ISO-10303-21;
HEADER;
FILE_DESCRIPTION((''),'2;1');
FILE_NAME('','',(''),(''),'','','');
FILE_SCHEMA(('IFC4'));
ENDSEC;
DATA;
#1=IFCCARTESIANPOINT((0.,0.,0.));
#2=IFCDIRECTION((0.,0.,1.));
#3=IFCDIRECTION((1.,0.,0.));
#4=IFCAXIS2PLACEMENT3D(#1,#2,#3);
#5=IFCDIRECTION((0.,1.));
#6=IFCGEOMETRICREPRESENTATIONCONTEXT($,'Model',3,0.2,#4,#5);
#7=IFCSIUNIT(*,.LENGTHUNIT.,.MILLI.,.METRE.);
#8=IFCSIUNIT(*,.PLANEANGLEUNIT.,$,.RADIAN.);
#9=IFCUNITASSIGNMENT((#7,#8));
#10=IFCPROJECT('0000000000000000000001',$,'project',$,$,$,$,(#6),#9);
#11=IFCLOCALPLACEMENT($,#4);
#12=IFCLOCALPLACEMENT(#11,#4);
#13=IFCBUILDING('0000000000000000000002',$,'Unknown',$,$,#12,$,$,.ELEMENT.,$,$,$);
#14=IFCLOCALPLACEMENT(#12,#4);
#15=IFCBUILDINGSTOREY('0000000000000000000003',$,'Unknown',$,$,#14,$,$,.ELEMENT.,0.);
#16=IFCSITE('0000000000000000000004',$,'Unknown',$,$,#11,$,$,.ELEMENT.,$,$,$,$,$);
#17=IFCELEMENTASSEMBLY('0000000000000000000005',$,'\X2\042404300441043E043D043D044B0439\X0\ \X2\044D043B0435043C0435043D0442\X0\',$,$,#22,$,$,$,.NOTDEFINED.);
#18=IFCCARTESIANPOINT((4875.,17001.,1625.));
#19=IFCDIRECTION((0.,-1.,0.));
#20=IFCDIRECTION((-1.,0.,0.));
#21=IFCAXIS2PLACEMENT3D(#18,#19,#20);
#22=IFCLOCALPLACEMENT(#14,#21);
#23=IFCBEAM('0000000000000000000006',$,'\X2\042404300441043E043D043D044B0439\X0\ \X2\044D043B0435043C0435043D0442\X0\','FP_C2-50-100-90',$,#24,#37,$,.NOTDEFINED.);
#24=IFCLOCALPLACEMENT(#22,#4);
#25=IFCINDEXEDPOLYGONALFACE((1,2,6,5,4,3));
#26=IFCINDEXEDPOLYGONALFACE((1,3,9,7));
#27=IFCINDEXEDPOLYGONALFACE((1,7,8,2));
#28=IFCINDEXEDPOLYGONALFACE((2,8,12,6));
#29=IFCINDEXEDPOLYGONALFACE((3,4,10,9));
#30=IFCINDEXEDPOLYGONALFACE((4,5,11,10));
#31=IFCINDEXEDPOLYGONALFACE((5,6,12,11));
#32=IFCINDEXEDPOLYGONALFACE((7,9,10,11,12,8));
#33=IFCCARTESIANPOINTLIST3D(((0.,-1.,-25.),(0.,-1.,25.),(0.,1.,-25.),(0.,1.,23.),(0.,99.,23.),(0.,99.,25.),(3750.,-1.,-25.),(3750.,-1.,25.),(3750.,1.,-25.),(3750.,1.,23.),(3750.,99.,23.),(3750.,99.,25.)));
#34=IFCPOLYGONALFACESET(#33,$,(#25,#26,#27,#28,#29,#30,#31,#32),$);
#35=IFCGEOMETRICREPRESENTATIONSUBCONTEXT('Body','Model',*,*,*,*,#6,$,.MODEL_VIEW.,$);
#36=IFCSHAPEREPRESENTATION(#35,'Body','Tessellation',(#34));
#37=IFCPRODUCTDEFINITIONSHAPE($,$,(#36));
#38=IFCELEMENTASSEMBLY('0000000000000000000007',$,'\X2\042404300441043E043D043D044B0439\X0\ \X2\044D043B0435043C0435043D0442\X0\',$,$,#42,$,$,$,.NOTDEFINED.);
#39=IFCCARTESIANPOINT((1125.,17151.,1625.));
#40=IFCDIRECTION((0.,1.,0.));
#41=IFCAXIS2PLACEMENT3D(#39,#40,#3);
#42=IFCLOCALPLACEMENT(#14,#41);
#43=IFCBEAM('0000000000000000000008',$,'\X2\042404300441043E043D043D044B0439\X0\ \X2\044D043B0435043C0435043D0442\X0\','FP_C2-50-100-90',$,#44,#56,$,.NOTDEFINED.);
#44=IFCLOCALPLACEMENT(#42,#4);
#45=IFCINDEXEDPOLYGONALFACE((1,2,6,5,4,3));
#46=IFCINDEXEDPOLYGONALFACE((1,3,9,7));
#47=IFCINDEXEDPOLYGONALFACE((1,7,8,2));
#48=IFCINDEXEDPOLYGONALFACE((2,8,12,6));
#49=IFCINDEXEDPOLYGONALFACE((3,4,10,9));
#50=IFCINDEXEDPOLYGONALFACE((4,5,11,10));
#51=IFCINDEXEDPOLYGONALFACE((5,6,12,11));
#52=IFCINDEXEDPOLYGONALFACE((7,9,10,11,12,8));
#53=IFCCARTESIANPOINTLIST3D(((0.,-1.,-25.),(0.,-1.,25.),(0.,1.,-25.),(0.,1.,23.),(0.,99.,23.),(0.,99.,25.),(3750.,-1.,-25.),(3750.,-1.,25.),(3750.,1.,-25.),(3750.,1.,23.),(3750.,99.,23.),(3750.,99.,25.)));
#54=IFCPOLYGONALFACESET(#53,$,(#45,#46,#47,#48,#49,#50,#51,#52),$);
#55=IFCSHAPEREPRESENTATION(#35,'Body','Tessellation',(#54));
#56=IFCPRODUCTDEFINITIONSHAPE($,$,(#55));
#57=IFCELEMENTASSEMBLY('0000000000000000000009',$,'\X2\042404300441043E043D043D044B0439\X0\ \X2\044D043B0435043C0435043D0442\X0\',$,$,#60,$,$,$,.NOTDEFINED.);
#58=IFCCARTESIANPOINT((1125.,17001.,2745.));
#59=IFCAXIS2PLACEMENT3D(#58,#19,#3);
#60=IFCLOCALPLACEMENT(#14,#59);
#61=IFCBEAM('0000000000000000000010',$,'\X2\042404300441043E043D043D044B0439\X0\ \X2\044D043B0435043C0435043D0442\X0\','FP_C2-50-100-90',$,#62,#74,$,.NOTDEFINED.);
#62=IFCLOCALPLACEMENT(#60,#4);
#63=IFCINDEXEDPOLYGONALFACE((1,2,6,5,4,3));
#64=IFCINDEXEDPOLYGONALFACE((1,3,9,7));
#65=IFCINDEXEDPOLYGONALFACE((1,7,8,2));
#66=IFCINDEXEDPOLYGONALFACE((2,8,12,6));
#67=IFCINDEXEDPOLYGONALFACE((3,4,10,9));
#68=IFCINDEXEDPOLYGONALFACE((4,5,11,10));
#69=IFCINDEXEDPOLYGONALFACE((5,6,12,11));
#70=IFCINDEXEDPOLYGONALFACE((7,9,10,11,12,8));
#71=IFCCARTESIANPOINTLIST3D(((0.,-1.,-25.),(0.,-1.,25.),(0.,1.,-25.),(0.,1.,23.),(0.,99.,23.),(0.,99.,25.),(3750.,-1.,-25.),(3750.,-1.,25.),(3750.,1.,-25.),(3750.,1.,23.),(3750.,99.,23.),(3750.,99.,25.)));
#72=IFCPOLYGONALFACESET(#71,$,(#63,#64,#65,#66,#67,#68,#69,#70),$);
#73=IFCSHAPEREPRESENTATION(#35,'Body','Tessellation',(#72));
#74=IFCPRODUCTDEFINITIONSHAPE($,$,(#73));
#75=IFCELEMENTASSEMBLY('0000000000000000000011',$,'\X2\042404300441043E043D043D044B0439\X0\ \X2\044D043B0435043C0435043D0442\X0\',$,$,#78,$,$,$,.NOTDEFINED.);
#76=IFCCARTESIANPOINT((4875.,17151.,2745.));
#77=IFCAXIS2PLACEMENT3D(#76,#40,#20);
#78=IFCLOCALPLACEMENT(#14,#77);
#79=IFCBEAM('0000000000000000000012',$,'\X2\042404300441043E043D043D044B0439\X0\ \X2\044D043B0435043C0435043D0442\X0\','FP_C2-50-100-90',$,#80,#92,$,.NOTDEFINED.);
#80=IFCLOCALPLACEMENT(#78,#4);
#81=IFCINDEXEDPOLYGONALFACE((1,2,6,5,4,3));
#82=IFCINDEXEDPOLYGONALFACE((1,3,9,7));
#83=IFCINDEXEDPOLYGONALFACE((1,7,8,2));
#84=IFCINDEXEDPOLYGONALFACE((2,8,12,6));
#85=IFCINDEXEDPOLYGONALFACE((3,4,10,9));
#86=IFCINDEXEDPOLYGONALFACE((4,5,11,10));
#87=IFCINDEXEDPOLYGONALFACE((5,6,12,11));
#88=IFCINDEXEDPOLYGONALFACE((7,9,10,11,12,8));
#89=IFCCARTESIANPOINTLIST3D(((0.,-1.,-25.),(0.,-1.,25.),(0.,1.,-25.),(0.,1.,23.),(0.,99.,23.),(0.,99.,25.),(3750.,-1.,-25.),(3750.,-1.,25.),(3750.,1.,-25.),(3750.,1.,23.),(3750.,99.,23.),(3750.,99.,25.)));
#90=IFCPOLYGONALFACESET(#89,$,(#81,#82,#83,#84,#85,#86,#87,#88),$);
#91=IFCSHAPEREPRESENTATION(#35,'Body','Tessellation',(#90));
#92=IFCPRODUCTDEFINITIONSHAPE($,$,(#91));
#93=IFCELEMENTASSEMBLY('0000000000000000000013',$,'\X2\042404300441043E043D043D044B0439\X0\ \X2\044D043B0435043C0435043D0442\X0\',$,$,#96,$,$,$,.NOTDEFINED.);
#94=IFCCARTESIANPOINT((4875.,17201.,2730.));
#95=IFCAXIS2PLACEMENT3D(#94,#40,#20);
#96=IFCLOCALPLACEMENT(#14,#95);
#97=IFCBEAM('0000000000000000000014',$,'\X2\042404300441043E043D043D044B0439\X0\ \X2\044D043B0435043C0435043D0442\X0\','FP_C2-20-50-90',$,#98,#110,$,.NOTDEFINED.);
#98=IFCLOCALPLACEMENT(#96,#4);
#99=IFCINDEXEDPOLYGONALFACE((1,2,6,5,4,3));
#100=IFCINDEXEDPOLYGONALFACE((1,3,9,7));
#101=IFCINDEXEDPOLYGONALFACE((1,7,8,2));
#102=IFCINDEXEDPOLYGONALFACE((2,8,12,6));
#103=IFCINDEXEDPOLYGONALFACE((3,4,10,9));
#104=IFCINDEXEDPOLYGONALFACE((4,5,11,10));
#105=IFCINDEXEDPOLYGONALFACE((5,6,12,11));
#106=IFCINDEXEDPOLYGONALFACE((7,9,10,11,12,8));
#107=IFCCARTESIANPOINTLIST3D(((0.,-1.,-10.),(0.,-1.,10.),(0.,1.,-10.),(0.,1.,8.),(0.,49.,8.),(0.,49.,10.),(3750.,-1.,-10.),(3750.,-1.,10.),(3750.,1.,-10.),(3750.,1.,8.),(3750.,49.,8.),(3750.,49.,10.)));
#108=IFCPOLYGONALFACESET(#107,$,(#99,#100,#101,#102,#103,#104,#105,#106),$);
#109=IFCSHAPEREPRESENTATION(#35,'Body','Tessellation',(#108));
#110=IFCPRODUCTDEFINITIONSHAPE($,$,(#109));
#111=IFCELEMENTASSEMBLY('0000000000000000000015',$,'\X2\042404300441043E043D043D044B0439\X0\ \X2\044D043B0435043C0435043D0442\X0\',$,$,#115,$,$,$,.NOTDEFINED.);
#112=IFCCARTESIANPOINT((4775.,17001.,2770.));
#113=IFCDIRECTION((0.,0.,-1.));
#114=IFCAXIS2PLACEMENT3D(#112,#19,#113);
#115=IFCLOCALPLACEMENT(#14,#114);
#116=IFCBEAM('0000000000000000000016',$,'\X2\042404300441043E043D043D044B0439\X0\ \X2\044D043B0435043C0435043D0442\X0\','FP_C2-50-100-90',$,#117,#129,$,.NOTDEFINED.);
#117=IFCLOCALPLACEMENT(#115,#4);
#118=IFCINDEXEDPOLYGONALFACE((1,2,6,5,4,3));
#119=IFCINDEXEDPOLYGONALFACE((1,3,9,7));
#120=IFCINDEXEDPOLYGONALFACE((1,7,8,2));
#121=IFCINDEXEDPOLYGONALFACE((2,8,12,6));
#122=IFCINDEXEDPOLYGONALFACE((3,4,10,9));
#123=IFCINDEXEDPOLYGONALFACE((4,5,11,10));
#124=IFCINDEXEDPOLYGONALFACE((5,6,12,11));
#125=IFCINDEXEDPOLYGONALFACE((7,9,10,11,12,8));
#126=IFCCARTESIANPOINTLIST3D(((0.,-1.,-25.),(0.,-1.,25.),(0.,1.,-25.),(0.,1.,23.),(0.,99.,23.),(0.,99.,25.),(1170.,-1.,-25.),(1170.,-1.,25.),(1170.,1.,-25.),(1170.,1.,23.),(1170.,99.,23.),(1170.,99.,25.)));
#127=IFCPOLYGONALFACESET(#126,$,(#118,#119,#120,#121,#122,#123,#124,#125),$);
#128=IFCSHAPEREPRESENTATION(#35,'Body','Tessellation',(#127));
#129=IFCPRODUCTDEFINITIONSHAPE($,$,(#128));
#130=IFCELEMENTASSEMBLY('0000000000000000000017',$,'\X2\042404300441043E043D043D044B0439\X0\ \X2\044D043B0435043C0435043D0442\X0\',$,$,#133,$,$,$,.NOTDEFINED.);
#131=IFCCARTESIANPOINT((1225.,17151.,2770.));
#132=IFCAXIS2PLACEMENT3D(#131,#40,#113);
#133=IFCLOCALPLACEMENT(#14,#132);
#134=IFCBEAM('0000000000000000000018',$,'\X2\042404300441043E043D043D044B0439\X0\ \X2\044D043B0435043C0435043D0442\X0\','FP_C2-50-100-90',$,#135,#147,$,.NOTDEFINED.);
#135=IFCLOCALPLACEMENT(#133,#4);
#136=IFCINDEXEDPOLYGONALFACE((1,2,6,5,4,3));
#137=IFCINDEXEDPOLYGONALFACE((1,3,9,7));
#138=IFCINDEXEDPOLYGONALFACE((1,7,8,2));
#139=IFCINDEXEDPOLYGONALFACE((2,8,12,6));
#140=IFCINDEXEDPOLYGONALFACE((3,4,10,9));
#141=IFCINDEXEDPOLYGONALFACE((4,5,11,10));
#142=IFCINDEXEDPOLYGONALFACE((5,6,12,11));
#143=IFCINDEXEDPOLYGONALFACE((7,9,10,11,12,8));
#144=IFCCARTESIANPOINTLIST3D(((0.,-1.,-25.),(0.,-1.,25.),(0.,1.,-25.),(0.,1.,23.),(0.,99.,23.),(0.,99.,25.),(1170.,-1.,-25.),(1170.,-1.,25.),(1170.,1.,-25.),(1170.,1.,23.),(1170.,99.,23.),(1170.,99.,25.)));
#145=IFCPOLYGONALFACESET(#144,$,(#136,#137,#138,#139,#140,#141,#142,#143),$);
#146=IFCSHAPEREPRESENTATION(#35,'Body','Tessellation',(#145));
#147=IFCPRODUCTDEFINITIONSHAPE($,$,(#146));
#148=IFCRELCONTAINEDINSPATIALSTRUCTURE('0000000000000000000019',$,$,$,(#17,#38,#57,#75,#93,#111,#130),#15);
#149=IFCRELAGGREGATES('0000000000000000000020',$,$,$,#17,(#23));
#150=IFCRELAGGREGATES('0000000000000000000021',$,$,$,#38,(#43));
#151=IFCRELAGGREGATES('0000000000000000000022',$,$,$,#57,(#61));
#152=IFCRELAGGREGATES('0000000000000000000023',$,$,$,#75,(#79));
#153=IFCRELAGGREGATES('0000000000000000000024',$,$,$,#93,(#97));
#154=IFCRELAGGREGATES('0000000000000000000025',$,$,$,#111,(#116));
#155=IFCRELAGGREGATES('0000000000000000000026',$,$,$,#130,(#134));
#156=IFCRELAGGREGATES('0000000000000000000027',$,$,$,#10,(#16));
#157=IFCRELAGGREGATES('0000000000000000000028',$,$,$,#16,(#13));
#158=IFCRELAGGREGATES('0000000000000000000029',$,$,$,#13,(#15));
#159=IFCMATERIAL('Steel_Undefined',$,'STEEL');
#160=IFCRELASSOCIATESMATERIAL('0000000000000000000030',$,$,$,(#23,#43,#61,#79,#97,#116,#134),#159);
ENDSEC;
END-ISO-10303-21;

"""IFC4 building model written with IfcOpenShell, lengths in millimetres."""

from ifc_helpers import new_model, si_unit, direction, frame, origin_with_axes, place, context, subcontext, project, spatial, line, indexed_curve, outline, extrude, material, element, aggregate, save


model = new_model("IFC4")

# Units and contexts
model_context = context("Model", 3, precision=0.2, world=origin_with_axes(), true_north=direction((0.0, 1.0)))
body_context = subcontext(model_context, "Body", "Model", "MODEL_VIEW")
ifc_project = project(units=[si_unit("LENGTHUNIT", "METRE", prefix="MILLI"), si_unit("PLANEANGLEUNIT", "RADIAN")], contexts=[model_context])

# Site, building, storey
site_placement = place(None, origin_with_axes())
site = spatial("IfcSite", under=ifc_project, at=site_placement, Name="Unknown", CompositionType="ELEMENT")
building_placement = place(site_placement, origin_with_axes())
building = spatial("IfcBuilding", under=site, at=building_placement, Name="Unknown", CompositionType="ELEMENT")
storey_placement = place(building_placement, origin_with_axes())
storey = spatial("IfcBuildingStorey", under=building, at=storey_placement, Name="Unknown", CompositionType="ELEMENT", Elevation=0.0)

# Element assemblies, beams
assembly_1_placement = place(storey_placement, frame((4875.0, 17001.0, 1625.0), z_axis=(0.0, -1.0, 0.0), x_axis=(-1.0, 0.0, 0.0)))
assembly_1 = element("IfcElementAssembly", 1, at=assembly_1_placement, inside=storey, Name="Фасонный элемент", PredefinedType="NOTDEFINED")
ifc_material_1 = material(Name="Steel_Undefined", Category="STEEL")
beam_1_placement = place(assembly_1_placement, origin_with_axes())
beam_1 = element("IfcBeam", 2, at=beam_1_placement, material=ifc_material_1, Name="Фасонный элемент", Description="FP_C2-50-100-90", PredefinedType="NOTDEFINED", context=body_context, shape_type="SolidModel", body=[
    extrude(outline(indexed_curve([(-25.0, -1.0), (25.0, -1.0), (25.0, 99.0), (23.0, 99.0), (23.0, 1.0), (-25.0, 1.0)], segments=[line(1, 2, 3, 4, 5, 6, 1)])), frame((0.0, 0.0, 0.0), z_axis=(-1.0, 0.0, 0.0), x_axis=(0.0, 0.0, 1.0)), (0.0, 0.0, -1.0), 3750.0),
])
aggregate(assembly_1, [beam_1])
assembly_2_placement = place(storey_placement, frame((1125.0, 17151.0, 1625.0), z_axis=(0.0, 1.0, 0.0), x_axis=(1.0, 0.0, 0.0)))
assembly_2 = element("IfcElementAssembly", 3, at=assembly_2_placement, inside=storey, Name="Фасонный элемент", PredefinedType="NOTDEFINED")
beam_2_placement = place(assembly_2_placement, origin_with_axes())
beam_2 = element("IfcBeam", 4, at=beam_2_placement, material=ifc_material_1, Name="Фасонный элемент", Description="FP_C2-50-100-90", PredefinedType="NOTDEFINED", context=body_context, shape_type="SolidModel", body=[
    extrude(outline(indexed_curve([(-25.0, -1.0), (25.0, -1.0), (25.0, 99.0), (23.0, 99.0), (23.0, 1.0), (-25.0, 1.0)], segments=[line(1, 2, 3, 4, 5, 6, 1)])), frame((0.0, 0.0, 0.0), z_axis=(-1.0, 0.0, 0.0), x_axis=(0.0, 0.0, 1.0)), (0.0, 0.0, -1.0), 3750.0),
])
aggregate(assembly_2, [beam_2])
assembly_3_placement = place(storey_placement, frame((1125.0, 17001.0, 2745.0), z_axis=(0.0, -1.0, 0.0), x_axis=(1.0, 0.0, 0.0)))
assembly_3 = element("IfcElementAssembly", 5, at=assembly_3_placement, inside=storey, Name="Фасонный элемент", PredefinedType="NOTDEFINED")
beam_3_placement = place(assembly_3_placement, origin_with_axes())
beam_3 = element("IfcBeam", 6, at=beam_3_placement, material=ifc_material_1, Name="Фасонный элемент", Description="FP_C2-50-100-90", PredefinedType="NOTDEFINED", context=body_context, shape_type="SolidModel", body=[
    extrude(outline(indexed_curve([(-25.0, -1.0), (25.0, -1.0), (25.0, 99.0), (23.0, 99.0), (23.0, 1.0), (-25.0, 1.0)], segments=[line(1, 2, 3, 4, 5, 6, 1)])), frame((0.0, 0.0, 0.0), z_axis=(-1.0, 0.0, 0.0), x_axis=(0.0, 0.0, 1.0)), (0.0, 0.0, -1.0), 3750.0),
])
aggregate(assembly_3, [beam_3])
assembly_4_placement = place(storey_placement, frame((4875.0, 17151.0, 2745.0), z_axis=(0.0, 1.0, 0.0), x_axis=(-1.0, 0.0, 0.0)))
assembly_4 = element("IfcElementAssembly", 7, at=assembly_4_placement, inside=storey, Name="Фасонный элемент", PredefinedType="NOTDEFINED")
beam_4_placement = place(assembly_4_placement, origin_with_axes())
beam_4 = element("IfcBeam", 8, at=beam_4_placement, material=ifc_material_1, Name="Фасонный элемент", Description="FP_C2-50-100-90", PredefinedType="NOTDEFINED", context=body_context, shape_type="SolidModel", body=[
    extrude(outline(indexed_curve([(-25.0, -1.0), (25.0, -1.0), (25.0, 99.0), (23.0, 99.0), (23.0, 1.0), (-25.0, 1.0)], segments=[line(1, 2, 3, 4, 5, 6, 1)])), frame((0.0, 0.0, 0.0), z_axis=(-1.0, 0.0, 0.0), x_axis=(0.0, 0.0, 1.0)), (0.0, 0.0, -1.0), 3750.0),
])
aggregate(assembly_4, [beam_4])
assembly_5_placement = place(storey_placement, frame((4875.0, 17201.0, 2730.0), z_axis=(0.0, 1.0, 0.0), x_axis=(-1.0, 0.0, 0.0)))
assembly_5 = element("IfcElementAssembly", 9, at=assembly_5_placement, inside=storey, Name="Фасонный элемент", PredefinedType="NOTDEFINED")
beam_5_placement = place(assembly_5_placement, origin_with_axes())
beam_5 = element("IfcBeam", 10, at=beam_5_placement, material=ifc_material_1, Name="Фасонный элемент", Description="FP_C2-20-50-90", PredefinedType="NOTDEFINED", context=body_context, shape_type="SolidModel", body=[
    extrude(outline(indexed_curve([(-10.0, -1.0), (10.0, -1.0), (10.0, 49.0), (8.0, 49.0), (8.0, 1.0), (-10.0, 1.0)], segments=[line(1, 2, 3, 4, 5, 6, 1)])), frame((0.0, 0.0, 0.0), z_axis=(-1.0, 0.0, 0.0), x_axis=(0.0, 0.0, 1.0)), (0.0, 0.0, -1.0), 3750.0),
])
aggregate(assembly_5, [beam_5])
assembly_6_placement = place(storey_placement, frame((4775.0, 17001.0, 2770.0), z_axis=(0.0, -1.0, 0.0), x_axis=(0.0, 0.0, -1.0)))
assembly_6 = element("IfcElementAssembly", 11, at=assembly_6_placement, inside=storey, Name="Фасонный элемент", PredefinedType="NOTDEFINED")
beam_6_placement = place(assembly_6_placement, origin_with_axes())
beam_6 = element("IfcBeam", 12, at=beam_6_placement, material=ifc_material_1, Name="Фасонный элемент", Description="FP_C2-50-100-90", PredefinedType="NOTDEFINED", context=body_context, shape_type="SolidModel", body=[
    extrude(outline(indexed_curve([(-25.0, -1.0), (25.0, -1.0), (25.0, 99.0), (23.0, 99.0), (23.0, 1.0), (-25.0, 1.0)], segments=[line(1, 2, 3, 4, 5, 6, 1)])), frame((0.0, 0.0, 0.0), z_axis=(-1.0, 0.0, 0.0), x_axis=(0.0, 0.0, 1.0)), (0.0, 0.0, -1.0), 1170.0),
])
aggregate(assembly_6, [beam_6])
assembly_7_placement = place(storey_placement, frame((1225.0, 17151.0, 2770.0), z_axis=(0.0, 1.0, 0.0), x_axis=(0.0, 0.0, -1.0)))
assembly_7 = element("IfcElementAssembly", 13, at=assembly_7_placement, inside=storey, Name="Фасонный элемент", PredefinedType="NOTDEFINED")
beam_7_placement = place(assembly_7_placement, origin_with_axes())
beam_7 = element("IfcBeam", 14, at=beam_7_placement, material=ifc_material_1, Name="Фасонный элемент", Description="FP_C2-50-100-90", PredefinedType="NOTDEFINED", context=body_context, shape_type="SolidModel", body=[
    extrude(outline(indexed_curve([(-25.0, -1.0), (25.0, -1.0), (25.0, 99.0), (23.0, 99.0), (23.0, 1.0), (-25.0, 1.0)], segments=[line(1, 2, 3, 4, 5, 6, 1)])), frame((0.0, 0.0, 0.0), z_axis=(-1.0, 0.0, 0.0), x_axis=(0.0, 0.0, 1.0)), (0.0, 0.0, -1.0), 1170.0),
])
aggregate(assembly_7, [beam_7])

save(model, "model.ifc")
